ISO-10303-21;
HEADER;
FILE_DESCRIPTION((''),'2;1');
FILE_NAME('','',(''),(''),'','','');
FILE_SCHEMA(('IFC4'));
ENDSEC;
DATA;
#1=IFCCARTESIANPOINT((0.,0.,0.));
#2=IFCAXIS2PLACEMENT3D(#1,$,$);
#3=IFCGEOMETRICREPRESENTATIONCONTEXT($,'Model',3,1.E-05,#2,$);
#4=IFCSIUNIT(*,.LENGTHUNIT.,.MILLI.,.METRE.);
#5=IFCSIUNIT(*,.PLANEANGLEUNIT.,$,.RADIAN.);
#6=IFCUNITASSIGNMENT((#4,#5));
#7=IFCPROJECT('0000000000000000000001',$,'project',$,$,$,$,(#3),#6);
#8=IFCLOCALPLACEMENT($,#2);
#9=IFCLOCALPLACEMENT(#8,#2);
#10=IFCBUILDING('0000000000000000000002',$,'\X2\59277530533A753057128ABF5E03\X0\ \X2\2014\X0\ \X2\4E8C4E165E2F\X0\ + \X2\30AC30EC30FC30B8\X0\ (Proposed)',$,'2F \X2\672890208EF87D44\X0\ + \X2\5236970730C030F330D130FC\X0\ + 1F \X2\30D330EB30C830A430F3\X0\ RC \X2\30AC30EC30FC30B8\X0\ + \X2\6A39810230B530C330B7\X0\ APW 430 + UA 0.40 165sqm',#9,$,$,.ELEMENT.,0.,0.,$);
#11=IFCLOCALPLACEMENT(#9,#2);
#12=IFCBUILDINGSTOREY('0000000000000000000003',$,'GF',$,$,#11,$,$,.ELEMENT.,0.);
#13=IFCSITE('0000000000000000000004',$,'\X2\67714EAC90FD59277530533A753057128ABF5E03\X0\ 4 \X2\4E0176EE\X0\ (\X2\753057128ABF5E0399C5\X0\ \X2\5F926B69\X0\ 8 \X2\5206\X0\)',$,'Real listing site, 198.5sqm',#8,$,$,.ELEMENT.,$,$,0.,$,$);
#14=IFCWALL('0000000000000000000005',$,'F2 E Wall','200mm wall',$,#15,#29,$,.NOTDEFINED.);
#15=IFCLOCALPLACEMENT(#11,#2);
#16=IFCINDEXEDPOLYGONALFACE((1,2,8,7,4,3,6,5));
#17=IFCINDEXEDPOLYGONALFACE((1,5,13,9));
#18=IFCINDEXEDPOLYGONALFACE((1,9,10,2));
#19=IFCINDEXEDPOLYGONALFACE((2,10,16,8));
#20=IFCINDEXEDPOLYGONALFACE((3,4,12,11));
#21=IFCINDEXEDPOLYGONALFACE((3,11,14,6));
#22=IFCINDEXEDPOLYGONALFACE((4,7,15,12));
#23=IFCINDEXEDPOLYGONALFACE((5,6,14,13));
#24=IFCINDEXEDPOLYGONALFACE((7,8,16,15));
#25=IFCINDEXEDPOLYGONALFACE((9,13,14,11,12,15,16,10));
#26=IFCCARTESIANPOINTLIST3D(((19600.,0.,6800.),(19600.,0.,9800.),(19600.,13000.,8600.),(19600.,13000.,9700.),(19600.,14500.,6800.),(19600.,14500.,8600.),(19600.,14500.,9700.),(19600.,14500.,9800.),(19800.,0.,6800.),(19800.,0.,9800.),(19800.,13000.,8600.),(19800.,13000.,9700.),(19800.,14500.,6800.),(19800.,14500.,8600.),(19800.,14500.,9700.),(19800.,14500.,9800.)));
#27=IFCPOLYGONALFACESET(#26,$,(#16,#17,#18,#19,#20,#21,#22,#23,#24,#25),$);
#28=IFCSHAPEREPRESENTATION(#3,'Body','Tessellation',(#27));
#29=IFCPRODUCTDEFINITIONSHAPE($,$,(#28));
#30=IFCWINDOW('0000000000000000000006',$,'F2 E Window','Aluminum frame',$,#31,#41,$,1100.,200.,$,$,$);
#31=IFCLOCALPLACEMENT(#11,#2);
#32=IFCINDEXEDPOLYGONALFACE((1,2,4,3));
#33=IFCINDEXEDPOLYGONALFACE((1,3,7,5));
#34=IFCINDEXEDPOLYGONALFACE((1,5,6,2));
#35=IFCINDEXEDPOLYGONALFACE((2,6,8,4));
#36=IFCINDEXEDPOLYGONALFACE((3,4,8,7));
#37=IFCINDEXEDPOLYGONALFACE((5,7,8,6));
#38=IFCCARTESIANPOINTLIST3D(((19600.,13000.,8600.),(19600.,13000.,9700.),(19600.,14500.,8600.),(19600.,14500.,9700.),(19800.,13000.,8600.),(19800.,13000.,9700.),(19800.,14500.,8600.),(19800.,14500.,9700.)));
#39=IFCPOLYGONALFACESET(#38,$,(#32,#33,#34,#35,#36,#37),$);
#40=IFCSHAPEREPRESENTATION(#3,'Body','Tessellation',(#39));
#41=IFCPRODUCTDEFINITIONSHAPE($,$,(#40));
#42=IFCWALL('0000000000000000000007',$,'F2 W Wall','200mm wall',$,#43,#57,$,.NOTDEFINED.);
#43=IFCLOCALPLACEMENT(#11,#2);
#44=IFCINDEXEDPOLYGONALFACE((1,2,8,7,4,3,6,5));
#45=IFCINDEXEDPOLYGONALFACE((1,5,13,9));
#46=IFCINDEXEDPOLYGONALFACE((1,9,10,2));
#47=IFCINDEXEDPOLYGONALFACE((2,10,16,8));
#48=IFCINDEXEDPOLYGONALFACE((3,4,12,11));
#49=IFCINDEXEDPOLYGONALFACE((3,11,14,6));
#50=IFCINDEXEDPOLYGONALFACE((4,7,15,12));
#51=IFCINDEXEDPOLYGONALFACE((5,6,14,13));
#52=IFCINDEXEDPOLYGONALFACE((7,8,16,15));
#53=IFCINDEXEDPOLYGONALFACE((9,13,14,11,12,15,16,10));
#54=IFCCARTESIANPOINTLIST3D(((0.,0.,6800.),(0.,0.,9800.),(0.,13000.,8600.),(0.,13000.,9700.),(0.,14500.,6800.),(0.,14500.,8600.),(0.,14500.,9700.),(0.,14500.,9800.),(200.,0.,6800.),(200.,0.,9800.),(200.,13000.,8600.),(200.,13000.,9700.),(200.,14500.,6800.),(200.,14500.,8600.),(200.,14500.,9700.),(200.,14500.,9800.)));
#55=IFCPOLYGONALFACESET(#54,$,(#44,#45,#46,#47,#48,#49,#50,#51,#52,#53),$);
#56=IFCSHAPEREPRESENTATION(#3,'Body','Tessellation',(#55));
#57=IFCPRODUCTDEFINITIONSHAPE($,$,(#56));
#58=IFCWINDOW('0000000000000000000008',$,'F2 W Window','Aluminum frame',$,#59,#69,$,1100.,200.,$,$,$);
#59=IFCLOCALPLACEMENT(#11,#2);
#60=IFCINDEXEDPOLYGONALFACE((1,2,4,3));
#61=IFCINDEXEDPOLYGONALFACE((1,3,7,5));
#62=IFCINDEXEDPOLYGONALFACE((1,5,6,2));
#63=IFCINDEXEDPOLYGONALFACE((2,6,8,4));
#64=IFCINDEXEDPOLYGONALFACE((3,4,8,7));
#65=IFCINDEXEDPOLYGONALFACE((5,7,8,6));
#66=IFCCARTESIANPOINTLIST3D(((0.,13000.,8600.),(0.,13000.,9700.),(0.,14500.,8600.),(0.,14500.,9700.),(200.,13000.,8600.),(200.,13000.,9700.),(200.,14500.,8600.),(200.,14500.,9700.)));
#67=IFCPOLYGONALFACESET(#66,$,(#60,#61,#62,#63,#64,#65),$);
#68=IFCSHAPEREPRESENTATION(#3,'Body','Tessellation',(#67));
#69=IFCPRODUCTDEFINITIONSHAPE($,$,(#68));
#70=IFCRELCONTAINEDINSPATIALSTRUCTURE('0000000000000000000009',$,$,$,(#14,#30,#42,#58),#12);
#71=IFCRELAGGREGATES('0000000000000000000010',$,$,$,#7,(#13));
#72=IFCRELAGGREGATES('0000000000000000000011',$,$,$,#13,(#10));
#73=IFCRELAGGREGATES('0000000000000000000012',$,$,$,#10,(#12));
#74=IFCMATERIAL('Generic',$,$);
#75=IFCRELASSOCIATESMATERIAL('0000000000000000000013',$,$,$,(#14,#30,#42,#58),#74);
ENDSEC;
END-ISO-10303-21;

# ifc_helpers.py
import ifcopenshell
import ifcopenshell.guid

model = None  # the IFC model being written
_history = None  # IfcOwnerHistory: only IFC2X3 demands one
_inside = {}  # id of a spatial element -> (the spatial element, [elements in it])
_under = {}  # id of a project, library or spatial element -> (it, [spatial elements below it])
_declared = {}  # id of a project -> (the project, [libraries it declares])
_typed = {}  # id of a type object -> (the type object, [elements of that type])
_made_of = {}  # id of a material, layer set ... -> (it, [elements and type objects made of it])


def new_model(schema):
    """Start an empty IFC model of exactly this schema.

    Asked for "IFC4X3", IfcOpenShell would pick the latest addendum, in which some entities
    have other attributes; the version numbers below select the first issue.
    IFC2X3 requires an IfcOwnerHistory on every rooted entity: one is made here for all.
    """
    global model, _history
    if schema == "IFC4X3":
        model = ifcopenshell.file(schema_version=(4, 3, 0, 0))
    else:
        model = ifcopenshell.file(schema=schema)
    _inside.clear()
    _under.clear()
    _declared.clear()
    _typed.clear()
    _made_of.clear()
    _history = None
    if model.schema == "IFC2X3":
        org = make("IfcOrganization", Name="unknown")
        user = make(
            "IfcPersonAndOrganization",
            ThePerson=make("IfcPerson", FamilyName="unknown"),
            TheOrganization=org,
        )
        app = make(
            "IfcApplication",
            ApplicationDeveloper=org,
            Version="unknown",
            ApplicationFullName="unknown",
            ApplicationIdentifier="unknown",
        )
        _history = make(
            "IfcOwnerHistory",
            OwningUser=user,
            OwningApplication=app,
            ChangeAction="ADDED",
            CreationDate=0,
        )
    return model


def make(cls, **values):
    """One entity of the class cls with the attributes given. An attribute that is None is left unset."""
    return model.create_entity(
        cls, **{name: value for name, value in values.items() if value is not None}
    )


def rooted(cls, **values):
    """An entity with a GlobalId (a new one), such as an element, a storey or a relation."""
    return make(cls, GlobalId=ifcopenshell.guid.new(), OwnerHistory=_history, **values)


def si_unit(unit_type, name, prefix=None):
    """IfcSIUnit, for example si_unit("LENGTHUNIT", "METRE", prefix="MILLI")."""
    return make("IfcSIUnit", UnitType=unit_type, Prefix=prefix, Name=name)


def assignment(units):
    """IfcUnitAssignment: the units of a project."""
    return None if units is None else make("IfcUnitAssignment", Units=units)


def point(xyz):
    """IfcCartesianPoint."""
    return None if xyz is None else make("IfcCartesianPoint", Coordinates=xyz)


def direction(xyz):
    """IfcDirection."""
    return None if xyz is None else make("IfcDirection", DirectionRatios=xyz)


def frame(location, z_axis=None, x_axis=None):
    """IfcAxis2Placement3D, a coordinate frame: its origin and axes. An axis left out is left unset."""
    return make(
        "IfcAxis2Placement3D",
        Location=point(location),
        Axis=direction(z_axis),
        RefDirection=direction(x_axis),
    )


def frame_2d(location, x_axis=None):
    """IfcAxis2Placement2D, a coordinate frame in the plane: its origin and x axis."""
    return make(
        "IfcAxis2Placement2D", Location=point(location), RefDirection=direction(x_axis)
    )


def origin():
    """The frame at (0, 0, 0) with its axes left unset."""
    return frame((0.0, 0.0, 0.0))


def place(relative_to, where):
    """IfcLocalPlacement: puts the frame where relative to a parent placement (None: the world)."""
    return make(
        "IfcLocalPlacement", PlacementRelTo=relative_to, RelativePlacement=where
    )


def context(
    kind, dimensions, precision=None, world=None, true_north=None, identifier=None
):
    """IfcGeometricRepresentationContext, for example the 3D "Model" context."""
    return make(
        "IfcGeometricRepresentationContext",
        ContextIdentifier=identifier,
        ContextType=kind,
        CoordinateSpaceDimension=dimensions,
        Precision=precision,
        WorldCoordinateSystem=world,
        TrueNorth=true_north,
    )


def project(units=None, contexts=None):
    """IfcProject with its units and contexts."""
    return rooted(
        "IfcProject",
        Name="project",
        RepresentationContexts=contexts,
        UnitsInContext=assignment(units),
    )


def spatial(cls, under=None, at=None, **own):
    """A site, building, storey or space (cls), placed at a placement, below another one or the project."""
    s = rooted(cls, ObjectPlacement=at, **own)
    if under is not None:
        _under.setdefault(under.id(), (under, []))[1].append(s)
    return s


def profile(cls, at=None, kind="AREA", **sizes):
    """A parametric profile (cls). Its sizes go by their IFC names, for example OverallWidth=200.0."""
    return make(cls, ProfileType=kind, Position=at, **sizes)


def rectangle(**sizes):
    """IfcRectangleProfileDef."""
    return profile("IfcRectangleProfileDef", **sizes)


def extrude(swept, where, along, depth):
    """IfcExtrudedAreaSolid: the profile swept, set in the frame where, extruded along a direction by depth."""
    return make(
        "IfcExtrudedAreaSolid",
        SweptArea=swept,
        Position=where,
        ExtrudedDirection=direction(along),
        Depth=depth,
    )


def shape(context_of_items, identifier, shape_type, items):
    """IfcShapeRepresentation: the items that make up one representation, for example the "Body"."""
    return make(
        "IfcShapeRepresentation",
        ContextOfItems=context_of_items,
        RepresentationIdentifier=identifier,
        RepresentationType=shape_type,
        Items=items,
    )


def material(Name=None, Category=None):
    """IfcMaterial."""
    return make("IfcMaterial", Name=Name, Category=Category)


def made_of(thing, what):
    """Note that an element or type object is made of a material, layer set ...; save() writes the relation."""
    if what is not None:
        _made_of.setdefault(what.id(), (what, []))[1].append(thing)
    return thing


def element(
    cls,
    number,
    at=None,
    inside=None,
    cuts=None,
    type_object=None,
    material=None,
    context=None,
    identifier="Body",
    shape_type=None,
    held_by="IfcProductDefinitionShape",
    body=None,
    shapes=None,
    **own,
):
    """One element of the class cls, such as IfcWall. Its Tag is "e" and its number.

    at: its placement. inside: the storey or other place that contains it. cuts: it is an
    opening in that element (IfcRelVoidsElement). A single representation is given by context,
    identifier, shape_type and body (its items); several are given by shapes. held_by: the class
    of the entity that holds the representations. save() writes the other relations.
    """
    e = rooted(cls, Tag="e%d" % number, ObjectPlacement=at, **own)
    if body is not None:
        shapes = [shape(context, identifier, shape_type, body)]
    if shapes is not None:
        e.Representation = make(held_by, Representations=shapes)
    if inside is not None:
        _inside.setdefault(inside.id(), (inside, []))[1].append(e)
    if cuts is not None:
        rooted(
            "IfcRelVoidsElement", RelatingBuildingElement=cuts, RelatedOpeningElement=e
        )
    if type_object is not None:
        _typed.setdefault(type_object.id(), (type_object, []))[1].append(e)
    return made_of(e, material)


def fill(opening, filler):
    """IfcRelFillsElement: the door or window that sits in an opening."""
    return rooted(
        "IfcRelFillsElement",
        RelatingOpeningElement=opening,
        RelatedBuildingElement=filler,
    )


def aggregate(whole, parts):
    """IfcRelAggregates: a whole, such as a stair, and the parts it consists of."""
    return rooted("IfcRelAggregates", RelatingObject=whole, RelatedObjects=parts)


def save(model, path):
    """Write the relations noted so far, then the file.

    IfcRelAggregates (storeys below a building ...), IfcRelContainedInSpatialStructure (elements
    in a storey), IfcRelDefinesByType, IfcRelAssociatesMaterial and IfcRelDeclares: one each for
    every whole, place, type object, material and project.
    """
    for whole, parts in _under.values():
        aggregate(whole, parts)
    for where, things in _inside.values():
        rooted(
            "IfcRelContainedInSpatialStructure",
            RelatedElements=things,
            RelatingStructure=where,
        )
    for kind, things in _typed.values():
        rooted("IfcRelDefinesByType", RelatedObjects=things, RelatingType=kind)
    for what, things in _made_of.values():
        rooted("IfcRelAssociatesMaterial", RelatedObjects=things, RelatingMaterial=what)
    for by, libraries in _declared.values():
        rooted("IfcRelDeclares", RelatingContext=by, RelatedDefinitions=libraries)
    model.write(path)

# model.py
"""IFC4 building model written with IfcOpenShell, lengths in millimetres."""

from ifc_helpers import new_model, si_unit, frame, frame_2d, origin, place, context, project, spatial, rectangle, extrude, material, element, fill, save


model = new_model("IFC4")

# Units and contexts
model_context = context("Model", 3, precision=1e-05, world=origin())
ifc_project = project(units=[si_unit("LENGTHUNIT", "METRE", prefix="MILLI"), si_unit("PLANEANGLEUNIT", "RADIAN")], contexts=[model_context])

# Site, building, storey
site_placement = place(None, origin())
site = spatial("IfcSite", under=ifc_project, at=site_placement, Name="東京都大田区田園調布 4 丁目 (田園調布駅 徒歩 8 分)", ObjectType="Real listing site, 198.5sqm", CompositionType="ELEMENT", RefElevation=0.0)
building_placement = place(site_placement, origin())
building = spatial("IfcBuilding", under=site, at=building_placement, Name="大田区田園調布 — 二世帯 + ガレージ (Proposed)", ObjectType="2F 木造軸組 + 制震ダンパー + 1F ビルトイン RC ガレージ + 樹脂サッシ APW 430 + UA 0.40 165sqm", CompositionType="ELEMENT", ElevationOfRefHeight=0.0, ElevationOfTerrain=0.0)
storey_placement = place(building_placement, origin())
storey = spatial("IfcBuildingStorey", under=building, at=storey_placement, Name="GF", CompositionType="ELEMENT", Elevation=0.0)

# Shared definitions
ifc_material_1 = material(Name="Generic")

# Walls, openings, windows
wall_1_placement = place(storey_placement, frame((9800.0, 0.0, 3400.0)))
wall_1 = element("IfcWall", 1, at=wall_1_placement, inside=storey, material=ifc_material_1, Name="F2 E Wall", Description="200mm wall", PredefinedType="NOTDEFINED", context=model_context, shape_type="SweptSolid", body=[
    extrude(rectangle(XDim=200.0, YDim=14500.0, at=frame_2d((100.0, 7250.0))), frame((9800.0, 0.0, 3400.0)), (0.0, 0.0, 1.0), 3000.0),
])
opening_1_placement = place(storey_placement, frame((9800.0, 6500.0, 4300.0)))
opening_1 = element("IfcOpeningElement", 2, at=opening_1_placement, cuts=wall_1, PredefinedType="NOTDEFINED", context=model_context, shape_type="SweptSolid", body=[
    extrude(rectangle(XDim=200.0, YDim=1500.0, at=frame_2d((100.0, 750.0))), frame((9800.0, 6500.0, 4300.0)), (0.0, 0.0, 1.0), 1100.0),
])
window_1_placement = place(storey_placement, frame((9800.0, 6500.0, 4300.0)))
window_1 = element("IfcWindow", 3, at=window_1_placement, inside=storey, material=ifc_material_1, Name="F2 E Window", Description="Aluminum frame", OverallHeight=1100.0, OverallWidth=200.0, context=model_context, shape_type="SweptSolid", body=[
    extrude(rectangle(XDim=200.0, YDim=1500.0, at=frame_2d((100.0, 750.0))), frame((9800.0, 6500.0, 4300.0)), (0.0, 0.0, 1.0), 1100.0),
])
fill(opening_1, window_1)
wall_2_placement = place(storey_placement, frame((0.0, 0.0, 3400.0)))
wall_2 = element("IfcWall", 4, at=wall_2_placement, inside=storey, material=ifc_material_1, Name="F2 W Wall", Description="200mm wall", PredefinedType="NOTDEFINED", context=model_context, shape_type="SweptSolid", body=[
    extrude(rectangle(XDim=200.0, YDim=14500.0, at=frame_2d((100.0, 7250.0))), frame((0.0, 0.0, 3400.0)), (0.0, 0.0, 1.0), 3000.0),
])
opening_2_placement = place(storey_placement, frame((0.0, 6500.0, 4300.0)))
opening_2 = element("IfcOpeningElement", 5, at=opening_2_placement, cuts=wall_2, PredefinedType="NOTDEFINED", context=model_context, shape_type="SweptSolid", body=[
    extrude(rectangle(XDim=200.0, YDim=1500.0, at=frame_2d((100.0, 750.0))), frame((0.0, 6500.0, 4300.0)), (0.0, 0.0, 1.0), 1100.0),
])
window_2_placement = place(storey_placement, frame((0.0, 6500.0, 4300.0)))
window_2 = element("IfcWindow", 6, at=window_2_placement, inside=storey, material=ifc_material_1, Name="F2 W Window", Description="Aluminum frame", OverallHeight=1100.0, OverallWidth=200.0, context=model_context, shape_type="SweptSolid", body=[
    extrude(rectangle(XDim=200.0, YDim=1500.0, at=frame_2d((100.0, 750.0))), frame((0.0, 6500.0, 4300.0)), (0.0, 0.0, 1.0), 1100.0),
])
fill(opening_2, window_2)

save(model, "model.ifc")
